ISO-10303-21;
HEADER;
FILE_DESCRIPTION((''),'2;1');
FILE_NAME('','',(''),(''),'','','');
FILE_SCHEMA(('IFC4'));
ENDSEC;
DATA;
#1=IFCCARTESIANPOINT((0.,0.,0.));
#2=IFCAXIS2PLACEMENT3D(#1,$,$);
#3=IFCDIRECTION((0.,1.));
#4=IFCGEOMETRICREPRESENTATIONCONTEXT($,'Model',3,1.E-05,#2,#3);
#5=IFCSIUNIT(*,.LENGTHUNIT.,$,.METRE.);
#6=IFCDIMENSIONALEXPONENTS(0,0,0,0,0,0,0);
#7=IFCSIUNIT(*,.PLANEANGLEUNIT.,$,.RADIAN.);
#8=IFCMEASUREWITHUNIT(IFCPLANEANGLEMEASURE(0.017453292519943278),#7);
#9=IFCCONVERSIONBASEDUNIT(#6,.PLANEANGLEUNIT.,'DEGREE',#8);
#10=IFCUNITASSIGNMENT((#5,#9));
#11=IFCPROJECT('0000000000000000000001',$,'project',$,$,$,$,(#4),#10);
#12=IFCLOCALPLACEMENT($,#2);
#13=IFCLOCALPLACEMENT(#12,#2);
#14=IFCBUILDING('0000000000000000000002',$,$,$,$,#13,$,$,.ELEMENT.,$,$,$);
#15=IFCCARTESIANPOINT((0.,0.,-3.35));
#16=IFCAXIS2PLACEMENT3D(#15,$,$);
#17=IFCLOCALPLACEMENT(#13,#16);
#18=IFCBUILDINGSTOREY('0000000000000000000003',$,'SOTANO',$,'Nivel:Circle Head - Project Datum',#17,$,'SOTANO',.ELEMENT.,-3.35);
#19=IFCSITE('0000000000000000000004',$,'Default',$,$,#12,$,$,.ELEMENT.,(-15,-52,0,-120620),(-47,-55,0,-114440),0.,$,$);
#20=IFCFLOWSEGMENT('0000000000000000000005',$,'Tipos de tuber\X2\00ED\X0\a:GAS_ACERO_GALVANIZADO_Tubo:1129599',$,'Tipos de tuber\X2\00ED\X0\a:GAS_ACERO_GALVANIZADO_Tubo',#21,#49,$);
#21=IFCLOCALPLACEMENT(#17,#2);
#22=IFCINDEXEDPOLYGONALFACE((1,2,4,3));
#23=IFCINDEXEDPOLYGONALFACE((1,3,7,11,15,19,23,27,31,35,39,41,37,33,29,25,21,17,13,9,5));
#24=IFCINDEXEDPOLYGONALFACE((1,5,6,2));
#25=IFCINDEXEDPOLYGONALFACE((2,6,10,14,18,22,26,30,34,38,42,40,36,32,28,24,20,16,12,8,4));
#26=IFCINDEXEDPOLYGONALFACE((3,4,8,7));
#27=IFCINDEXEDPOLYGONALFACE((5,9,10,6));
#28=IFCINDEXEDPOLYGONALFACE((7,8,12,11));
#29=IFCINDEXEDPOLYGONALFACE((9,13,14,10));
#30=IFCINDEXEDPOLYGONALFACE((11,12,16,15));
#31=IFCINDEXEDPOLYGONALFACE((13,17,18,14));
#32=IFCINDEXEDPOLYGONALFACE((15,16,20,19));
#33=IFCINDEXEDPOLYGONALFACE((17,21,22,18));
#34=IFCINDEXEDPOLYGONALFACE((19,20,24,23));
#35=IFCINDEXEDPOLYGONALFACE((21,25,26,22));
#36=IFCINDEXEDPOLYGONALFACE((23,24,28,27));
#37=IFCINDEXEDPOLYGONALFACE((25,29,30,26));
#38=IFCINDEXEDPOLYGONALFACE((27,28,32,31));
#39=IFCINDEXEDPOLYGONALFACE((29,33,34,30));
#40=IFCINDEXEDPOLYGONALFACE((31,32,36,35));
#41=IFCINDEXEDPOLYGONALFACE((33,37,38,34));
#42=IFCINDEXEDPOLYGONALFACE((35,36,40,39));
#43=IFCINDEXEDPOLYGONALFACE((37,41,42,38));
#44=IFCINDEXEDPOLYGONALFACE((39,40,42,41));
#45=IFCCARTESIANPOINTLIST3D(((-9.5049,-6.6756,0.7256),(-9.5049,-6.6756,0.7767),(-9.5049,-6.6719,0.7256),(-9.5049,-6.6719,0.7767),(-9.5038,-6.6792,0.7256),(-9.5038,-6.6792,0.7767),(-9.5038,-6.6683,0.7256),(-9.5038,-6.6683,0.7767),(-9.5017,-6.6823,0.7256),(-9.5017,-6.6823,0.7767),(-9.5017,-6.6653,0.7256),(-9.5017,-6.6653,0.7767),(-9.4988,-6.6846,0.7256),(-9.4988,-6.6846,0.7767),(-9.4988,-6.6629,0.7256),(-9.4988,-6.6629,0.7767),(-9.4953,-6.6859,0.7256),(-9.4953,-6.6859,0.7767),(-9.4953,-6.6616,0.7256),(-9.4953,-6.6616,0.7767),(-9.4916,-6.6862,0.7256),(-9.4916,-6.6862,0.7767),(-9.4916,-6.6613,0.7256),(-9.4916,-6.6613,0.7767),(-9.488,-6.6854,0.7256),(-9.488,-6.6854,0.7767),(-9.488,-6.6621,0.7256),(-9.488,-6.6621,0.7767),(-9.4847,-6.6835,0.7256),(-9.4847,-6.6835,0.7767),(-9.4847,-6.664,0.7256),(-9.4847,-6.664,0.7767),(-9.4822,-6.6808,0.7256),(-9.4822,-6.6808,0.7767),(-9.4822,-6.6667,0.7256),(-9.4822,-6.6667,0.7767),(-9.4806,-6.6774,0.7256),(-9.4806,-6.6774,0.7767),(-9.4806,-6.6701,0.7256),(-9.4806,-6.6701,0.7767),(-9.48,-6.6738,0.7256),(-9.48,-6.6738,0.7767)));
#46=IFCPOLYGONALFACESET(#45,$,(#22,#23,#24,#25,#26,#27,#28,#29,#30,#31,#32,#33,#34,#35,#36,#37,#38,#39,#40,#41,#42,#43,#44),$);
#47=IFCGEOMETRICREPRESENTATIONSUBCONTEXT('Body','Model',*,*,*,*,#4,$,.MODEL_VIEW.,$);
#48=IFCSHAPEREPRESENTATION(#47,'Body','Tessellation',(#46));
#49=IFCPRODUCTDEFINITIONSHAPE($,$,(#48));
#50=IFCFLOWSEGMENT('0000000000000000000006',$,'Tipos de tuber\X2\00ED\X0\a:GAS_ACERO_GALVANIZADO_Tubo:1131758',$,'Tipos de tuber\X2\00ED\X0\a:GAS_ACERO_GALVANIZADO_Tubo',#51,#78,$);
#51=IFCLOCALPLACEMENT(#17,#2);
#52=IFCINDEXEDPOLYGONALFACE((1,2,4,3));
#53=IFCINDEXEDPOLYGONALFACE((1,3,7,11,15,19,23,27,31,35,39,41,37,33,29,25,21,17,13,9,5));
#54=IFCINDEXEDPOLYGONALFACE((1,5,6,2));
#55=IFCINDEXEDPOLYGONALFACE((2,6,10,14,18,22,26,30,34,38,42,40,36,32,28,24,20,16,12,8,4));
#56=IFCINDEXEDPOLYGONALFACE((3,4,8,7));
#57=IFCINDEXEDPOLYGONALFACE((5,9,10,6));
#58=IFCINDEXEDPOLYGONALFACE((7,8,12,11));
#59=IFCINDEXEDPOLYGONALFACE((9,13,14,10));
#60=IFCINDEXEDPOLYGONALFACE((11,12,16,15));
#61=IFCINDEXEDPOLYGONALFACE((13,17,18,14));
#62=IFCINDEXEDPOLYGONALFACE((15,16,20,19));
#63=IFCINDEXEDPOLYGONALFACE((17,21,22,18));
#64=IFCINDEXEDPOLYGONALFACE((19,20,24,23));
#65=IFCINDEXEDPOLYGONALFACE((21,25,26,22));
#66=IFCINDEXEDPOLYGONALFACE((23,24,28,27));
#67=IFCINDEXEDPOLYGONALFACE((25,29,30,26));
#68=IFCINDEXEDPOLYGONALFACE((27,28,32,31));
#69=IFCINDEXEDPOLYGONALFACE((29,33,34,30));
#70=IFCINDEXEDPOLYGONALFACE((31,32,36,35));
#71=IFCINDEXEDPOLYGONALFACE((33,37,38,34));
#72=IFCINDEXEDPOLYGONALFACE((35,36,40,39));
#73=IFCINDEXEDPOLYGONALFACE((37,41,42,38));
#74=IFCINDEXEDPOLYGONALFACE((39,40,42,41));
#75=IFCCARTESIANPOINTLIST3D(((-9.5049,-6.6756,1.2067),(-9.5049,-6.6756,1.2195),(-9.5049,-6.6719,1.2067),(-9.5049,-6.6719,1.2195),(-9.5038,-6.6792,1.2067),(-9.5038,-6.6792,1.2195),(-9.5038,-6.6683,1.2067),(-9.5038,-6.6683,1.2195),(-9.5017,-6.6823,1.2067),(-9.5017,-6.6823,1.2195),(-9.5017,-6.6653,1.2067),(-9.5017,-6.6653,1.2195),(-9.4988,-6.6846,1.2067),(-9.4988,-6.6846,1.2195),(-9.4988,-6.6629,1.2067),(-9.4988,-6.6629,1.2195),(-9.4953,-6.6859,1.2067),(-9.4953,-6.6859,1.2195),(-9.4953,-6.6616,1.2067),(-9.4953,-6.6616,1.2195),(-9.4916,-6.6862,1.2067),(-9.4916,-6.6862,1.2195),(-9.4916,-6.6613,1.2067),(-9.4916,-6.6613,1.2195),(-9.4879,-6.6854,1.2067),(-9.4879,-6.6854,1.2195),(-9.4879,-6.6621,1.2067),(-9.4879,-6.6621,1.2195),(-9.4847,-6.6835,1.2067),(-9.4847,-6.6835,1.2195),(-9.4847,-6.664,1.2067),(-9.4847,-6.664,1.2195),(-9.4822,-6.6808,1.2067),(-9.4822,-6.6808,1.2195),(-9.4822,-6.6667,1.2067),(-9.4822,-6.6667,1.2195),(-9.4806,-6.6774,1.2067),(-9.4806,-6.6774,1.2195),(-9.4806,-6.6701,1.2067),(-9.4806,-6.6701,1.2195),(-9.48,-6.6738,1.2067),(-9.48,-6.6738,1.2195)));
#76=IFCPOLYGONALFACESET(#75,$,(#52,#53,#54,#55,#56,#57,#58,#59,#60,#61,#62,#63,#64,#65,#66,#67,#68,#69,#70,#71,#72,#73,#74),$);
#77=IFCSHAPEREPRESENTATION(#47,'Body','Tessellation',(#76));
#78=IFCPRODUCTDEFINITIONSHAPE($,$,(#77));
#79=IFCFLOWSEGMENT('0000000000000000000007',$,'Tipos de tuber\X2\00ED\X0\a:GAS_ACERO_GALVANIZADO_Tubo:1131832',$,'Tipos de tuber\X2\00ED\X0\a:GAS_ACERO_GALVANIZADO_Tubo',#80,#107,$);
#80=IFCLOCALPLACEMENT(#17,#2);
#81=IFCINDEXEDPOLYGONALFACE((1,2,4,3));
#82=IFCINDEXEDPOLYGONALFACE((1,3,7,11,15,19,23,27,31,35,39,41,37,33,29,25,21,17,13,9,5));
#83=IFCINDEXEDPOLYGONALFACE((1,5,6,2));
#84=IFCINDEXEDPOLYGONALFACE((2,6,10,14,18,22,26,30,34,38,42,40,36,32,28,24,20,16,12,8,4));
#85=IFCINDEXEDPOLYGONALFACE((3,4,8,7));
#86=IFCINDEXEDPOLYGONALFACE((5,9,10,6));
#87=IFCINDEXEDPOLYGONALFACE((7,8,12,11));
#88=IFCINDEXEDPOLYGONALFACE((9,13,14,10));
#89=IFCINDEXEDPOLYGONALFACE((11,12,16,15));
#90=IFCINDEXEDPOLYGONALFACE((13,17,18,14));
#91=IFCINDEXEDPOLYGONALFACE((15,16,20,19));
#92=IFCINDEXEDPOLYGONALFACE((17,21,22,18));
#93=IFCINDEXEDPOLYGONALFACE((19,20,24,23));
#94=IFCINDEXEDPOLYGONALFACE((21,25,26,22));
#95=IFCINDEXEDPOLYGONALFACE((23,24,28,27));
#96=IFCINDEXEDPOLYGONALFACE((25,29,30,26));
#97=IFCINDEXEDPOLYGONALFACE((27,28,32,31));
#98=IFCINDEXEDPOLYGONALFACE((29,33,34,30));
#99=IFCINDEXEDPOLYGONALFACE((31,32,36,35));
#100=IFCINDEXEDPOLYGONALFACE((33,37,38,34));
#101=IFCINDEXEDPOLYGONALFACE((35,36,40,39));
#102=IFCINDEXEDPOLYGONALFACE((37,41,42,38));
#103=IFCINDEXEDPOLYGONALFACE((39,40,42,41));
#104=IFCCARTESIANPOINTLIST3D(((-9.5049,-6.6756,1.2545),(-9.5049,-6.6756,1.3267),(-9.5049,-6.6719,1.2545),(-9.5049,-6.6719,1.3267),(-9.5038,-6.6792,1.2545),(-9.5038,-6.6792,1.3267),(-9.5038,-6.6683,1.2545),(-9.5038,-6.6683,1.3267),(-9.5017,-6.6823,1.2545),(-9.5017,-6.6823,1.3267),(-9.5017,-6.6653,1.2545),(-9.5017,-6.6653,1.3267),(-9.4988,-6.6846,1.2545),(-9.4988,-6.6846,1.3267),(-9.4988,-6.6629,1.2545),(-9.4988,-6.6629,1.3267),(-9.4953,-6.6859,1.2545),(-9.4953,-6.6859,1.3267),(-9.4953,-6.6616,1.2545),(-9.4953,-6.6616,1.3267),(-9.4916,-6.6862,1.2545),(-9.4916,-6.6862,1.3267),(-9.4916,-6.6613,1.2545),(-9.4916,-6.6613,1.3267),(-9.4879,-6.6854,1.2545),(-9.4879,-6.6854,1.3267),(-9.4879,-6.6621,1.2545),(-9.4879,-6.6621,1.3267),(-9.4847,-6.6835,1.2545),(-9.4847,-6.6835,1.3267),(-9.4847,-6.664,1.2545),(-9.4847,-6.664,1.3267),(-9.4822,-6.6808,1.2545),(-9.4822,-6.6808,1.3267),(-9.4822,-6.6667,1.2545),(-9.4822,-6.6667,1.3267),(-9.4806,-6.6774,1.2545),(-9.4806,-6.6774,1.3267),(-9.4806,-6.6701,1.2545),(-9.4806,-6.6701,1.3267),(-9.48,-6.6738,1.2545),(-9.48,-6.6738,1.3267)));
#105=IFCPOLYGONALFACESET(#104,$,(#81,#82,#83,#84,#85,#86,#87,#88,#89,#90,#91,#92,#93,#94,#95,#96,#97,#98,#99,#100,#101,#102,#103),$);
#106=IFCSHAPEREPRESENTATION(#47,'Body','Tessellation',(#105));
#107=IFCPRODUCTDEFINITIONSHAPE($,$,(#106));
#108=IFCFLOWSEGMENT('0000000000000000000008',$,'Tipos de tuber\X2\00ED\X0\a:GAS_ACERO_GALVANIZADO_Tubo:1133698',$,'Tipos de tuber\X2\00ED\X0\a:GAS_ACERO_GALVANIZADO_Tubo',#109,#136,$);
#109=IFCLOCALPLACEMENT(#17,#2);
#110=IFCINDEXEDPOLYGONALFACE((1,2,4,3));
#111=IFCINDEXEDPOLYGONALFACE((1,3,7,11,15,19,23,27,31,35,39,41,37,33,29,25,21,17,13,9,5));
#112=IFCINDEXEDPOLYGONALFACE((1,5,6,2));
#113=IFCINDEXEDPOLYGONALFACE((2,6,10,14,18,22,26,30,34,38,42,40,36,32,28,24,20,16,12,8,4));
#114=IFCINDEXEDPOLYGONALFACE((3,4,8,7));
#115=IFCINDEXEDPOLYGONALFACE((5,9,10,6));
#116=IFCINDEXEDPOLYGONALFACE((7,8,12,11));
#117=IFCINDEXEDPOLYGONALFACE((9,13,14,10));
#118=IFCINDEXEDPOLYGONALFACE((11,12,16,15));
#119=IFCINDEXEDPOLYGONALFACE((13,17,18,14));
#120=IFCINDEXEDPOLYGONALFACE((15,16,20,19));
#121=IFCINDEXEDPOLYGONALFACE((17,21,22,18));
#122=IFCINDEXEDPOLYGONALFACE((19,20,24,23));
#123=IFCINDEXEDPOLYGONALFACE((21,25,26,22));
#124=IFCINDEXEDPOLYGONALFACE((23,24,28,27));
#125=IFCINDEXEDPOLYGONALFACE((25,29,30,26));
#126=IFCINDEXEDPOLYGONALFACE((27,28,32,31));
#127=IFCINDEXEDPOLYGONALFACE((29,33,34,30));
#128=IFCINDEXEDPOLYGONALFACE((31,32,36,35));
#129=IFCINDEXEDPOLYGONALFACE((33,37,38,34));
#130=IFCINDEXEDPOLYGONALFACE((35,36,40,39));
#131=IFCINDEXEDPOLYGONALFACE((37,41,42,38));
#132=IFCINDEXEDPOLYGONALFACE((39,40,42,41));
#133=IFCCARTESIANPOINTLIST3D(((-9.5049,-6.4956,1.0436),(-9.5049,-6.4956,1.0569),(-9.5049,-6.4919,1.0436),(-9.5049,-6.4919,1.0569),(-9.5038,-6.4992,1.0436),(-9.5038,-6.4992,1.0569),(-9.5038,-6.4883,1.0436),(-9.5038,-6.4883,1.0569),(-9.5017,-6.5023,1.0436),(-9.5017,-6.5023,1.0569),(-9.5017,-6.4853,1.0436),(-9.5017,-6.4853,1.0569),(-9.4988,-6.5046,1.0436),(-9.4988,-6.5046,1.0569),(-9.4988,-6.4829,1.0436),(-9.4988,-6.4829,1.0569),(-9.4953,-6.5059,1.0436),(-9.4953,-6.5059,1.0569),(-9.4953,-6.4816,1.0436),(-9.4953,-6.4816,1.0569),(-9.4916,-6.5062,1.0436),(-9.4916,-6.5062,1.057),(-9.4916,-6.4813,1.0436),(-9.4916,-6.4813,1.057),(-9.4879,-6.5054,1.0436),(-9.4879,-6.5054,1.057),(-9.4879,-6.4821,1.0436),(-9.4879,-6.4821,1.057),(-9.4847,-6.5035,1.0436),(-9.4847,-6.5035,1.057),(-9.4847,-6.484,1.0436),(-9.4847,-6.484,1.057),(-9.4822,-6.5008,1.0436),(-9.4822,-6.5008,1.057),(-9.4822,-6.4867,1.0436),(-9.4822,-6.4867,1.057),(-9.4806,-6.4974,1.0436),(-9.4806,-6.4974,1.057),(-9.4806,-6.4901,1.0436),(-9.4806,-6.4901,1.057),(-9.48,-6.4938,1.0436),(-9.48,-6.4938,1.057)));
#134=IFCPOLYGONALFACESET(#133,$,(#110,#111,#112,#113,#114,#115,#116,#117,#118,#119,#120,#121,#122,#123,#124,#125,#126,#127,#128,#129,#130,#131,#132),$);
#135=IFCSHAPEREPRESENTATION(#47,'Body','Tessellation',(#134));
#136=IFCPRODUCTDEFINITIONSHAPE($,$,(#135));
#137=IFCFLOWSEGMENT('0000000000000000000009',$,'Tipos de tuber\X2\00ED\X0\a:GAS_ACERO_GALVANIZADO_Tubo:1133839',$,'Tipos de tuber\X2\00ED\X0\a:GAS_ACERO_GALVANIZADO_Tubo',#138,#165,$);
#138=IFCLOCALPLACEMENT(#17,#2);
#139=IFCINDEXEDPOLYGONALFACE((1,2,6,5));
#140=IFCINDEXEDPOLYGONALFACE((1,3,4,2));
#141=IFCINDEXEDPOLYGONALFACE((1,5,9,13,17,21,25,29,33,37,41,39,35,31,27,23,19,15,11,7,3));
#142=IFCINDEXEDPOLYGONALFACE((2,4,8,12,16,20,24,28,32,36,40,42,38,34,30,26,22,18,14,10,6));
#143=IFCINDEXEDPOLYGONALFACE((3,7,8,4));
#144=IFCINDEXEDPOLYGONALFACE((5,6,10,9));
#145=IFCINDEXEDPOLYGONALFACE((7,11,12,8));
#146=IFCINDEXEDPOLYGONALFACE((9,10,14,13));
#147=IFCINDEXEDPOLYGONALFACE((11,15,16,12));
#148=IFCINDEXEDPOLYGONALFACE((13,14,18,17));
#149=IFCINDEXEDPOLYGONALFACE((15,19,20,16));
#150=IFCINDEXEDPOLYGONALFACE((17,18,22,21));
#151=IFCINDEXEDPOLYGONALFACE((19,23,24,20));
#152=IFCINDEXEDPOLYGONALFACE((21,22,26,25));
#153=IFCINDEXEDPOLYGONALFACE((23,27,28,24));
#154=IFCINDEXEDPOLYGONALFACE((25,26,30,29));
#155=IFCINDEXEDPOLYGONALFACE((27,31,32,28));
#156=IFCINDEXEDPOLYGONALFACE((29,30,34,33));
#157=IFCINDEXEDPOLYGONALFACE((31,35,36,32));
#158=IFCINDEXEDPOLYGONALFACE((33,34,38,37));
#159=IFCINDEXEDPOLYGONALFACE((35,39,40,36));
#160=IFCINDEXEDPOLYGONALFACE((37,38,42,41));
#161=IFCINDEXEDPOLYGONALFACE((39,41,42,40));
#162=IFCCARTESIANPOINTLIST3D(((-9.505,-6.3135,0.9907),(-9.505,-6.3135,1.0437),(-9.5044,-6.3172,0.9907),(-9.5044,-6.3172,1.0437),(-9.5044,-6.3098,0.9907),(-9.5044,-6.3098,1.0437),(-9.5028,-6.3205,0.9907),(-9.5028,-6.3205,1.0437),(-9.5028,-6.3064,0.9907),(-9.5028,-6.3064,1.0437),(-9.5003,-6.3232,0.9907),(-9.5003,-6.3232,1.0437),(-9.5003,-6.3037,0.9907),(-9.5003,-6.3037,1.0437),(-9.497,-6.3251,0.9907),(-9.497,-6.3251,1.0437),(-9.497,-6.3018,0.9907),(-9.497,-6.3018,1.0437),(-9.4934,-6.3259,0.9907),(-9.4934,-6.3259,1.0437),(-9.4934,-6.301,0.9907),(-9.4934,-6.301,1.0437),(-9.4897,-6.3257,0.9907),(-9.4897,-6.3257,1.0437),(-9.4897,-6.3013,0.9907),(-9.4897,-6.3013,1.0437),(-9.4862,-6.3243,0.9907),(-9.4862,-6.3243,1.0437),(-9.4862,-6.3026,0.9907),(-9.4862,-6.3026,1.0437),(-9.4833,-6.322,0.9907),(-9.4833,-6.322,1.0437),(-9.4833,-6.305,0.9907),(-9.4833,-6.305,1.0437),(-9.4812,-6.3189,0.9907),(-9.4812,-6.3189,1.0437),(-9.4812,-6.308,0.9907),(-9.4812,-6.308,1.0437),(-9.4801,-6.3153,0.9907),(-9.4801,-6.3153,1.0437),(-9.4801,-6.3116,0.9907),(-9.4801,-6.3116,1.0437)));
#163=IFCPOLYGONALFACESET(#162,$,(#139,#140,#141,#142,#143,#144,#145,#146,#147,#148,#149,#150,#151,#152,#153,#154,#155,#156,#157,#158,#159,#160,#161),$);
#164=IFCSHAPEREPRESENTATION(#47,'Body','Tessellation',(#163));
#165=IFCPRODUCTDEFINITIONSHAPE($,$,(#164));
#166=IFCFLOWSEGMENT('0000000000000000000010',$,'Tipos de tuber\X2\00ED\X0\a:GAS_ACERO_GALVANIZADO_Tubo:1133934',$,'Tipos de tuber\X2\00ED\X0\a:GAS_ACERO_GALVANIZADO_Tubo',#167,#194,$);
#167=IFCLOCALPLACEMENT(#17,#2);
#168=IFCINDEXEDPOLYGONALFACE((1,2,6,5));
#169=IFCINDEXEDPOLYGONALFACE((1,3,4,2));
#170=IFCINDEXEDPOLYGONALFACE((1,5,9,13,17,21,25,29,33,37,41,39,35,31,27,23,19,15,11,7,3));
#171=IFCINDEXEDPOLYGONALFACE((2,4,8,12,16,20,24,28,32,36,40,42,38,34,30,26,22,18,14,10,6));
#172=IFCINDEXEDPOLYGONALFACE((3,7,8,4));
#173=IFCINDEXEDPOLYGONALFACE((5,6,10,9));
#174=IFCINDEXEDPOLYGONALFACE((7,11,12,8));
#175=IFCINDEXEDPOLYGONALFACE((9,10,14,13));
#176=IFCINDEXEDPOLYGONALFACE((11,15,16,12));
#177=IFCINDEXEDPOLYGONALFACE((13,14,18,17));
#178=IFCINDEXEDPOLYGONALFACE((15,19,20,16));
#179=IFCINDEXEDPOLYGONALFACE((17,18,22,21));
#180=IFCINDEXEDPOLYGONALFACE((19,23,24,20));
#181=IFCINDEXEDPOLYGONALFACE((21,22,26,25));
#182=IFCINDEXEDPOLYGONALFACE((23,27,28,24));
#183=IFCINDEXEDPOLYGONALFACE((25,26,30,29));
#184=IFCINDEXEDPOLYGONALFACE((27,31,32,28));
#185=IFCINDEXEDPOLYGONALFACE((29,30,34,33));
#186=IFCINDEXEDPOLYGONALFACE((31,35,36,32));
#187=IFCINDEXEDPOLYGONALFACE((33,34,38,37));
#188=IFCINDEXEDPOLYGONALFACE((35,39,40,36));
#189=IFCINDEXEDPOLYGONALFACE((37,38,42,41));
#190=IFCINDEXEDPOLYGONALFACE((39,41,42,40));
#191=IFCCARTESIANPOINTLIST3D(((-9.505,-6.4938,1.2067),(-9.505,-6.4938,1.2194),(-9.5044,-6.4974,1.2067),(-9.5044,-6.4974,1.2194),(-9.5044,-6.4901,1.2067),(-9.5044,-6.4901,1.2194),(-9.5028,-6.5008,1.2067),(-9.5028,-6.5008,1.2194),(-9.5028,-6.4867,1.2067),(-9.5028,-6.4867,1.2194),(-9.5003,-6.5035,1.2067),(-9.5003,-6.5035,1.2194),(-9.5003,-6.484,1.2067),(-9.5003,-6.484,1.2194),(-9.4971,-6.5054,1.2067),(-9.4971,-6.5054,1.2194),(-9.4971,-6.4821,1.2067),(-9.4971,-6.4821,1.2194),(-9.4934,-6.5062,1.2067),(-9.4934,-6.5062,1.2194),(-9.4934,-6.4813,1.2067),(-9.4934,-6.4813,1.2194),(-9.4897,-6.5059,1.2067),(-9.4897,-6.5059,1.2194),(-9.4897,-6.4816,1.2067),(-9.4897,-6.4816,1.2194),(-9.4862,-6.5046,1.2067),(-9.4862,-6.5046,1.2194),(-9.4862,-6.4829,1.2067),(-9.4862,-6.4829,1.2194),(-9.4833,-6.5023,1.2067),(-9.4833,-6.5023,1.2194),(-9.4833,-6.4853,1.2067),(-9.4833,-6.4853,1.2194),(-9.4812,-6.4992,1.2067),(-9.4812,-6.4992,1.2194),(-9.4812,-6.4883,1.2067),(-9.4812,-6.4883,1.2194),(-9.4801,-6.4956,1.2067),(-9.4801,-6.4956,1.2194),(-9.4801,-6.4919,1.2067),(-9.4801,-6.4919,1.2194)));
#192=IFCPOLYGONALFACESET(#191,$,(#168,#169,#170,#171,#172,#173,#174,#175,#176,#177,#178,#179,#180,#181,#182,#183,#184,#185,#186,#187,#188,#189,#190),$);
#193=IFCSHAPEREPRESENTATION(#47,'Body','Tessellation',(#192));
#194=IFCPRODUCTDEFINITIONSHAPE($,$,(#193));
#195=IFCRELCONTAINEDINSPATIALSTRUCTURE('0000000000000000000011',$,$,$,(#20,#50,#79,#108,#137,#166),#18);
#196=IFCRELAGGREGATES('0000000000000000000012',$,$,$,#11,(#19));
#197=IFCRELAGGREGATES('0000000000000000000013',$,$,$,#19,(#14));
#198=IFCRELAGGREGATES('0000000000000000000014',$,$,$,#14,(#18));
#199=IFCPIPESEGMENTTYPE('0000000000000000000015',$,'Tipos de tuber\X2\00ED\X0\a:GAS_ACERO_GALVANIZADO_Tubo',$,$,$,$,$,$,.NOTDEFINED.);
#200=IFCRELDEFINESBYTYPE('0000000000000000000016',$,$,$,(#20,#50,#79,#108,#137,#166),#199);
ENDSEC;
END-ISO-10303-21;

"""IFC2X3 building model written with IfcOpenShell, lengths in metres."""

from ifc_helpers import new_model, entity, si_unit, converted_unit, direction, frame, frame_2d, origin, origin_2d_with_axis, place, context, subcontext, project, spatial, circle, extrude, type_object, element, save


model = new_model("IFC2X3")

# Units and contexts
model_context = context("Model", 3, precision=1e-05, world=origin(), true_north=direction((0.0, 1.0)))
body_context = subcontext(model_context, "Body", "Model", "MODEL_VIEW")
ifc_project = project(units=[si_unit("LENGTHUNIT", "METRE"), converted_unit("PLANEANGLEUNIT", "DEGREE", entity("IfcPlaneAngleMeasure", 0.017453292519943278), si_unit("PLANEANGLEUNIT", "RADIAN"), dimensions=[0, 0, 0, 0, 0, 0, 0])], contexts=[model_context])

# Site, building, storey
site_placement = place(None, origin())
site = spatial("IfcSite", under=ifc_project, at=site_placement, Name="Default", CompositionType="ELEMENT", RefLatitude=(-15, -52, 0, -120620), RefLongitude=(-47, -55, 0, -114440), RefElevation=0.0)
building_placement = place(site_placement, origin())
building = spatial("IfcBuilding", under=site, at=building_placement, CompositionType="ELEMENT")
storey_placement = place(building_placement, frame((0.0, 0.0, -3.35)))
storey = spatial("IfcBuildingStorey", under=building, at=storey_placement, Name="SOTANO", ObjectType="Nivel:Circle Head - Project Datum", LongName="SOTANO", CompositionType="ELEMENT", Elevation=-3.35)

# Flow segments
pipe_segment_type_1 = type_object("IfcPipeSegmentType", Name="Tipos de tubería:GAS_ACERO_GALVANIZADO_Tubo", PredefinedType="NOTDEFINED")
flow_segment_1_placement = place(storey_placement, origin())
element("IfcFlowSegment", 1, at=flow_segment_1_placement, inside=storey, type_object=pipe_segment_type_1, Name="Tipos de tubería:GAS_ACERO_GALVANIZADO_Tubo:1129599", ObjectType="Tipos de tubería:GAS_ACERO_GALVANIZADO_Tubo", context=body_context, shape_type="SweptSolid", body=[
    extrude(circle(Radius=0.0125, at=origin_2d_with_axis()), frame((-9.4925, -6.6738, 0.7256)), (0.0, 0.0, 1.0), 0.051),
])
flow_segment_2_placement = place(storey_placement, origin())
element("IfcFlowSegment", 2, at=flow_segment_2_placement, inside=storey, type_object=pipe_segment_type_1, Name="Tipos de tubería:GAS_ACERO_GALVANIZADO_Tubo:1131758", ObjectType="Tipos de tubería:GAS_ACERO_GALVANIZADO_Tubo", context=body_context, shape_type="SweptSolid", body=[
    extrude(circle(Radius=0.0125, at=origin_2d_with_axis()), frame((-9.4925, -6.6738, 1.2067)), (0.0, 0.0, 1.0), 0.0128),
])
flow_segment_3_placement = place(storey_placement, origin())
element("IfcFlowSegment", 3, at=flow_segment_3_placement, inside=storey, type_object=pipe_segment_type_1, Name="Tipos de tubería:GAS_ACERO_GALVANIZADO_Tubo:1131832", ObjectType="Tipos de tubería:GAS_ACERO_GALVANIZADO_Tubo", context=body_context, shape_type="SweptSolid", body=[
    extrude(circle(Radius=0.0125, at=frame_2d((0.0, 0.0), x_axis=(1.0, 0.0))), frame((-9.4925, -6.6738, 1.2545)), (0.0, 0.0, 1.0), 0.0722),
])
flow_segment_4_placement = place(storey_placement, origin())
element("IfcFlowSegment", 4, at=flow_segment_4_placement, inside=storey, type_object=pipe_segment_type_1, Name="Tipos de tubería:GAS_ACERO_GALVANIZADO_Tubo:1133698", ObjectType="Tipos de tubería:GAS_ACERO_GALVANIZADO_Tubo", context=body_context, shape_type="SweptSolid", body=[
    extrude(circle(Radius=0.0125, at=frame_2d((0.0, 0.0), x_axis=(1.0, 0.0))), frame((-9.4925, -6.4938, 1.0436), z_axis=(-0.000174, 0.0, 1.0), x_axis=(1.0, 0.0, 0.000174)), (0.0, 0.0, 1.0), 0.0133),
])
flow_segment_5_placement = place(storey_placement, origin())
element("IfcFlowSegment", 5, at=flow_segment_5_placement, inside=storey, type_object=pipe_segment_type_1, Name="Tipos de tubería:GAS_ACERO_GALVANIZADO_Tubo:1133839", ObjectType="Tipos de tubería:GAS_ACERO_GALVANIZADO_Tubo", context=body_context, shape_type="SweptSolid", body=[
    extrude(circle(Radius=0.0125, at=origin_2d_with_axis()), frame((-9.4925, -6.3135, 0.9907), z_axis=(-0.000135, 0.0, 1.0), x_axis=(-1.0, 0.0, -0.000135)), (0.0, 0.0, 1.0), 0.053),
])
flow_segment_6_placement = place(storey_placement, origin())
element("IfcFlowSegment", 6, at=flow_segment_6_placement, inside=storey, type_object=pipe_segment_type_1, Name="Tipos de tubería:GAS_ACERO_GALVANIZADO_Tubo:1133934", ObjectType="Tipos de tubería:GAS_ACERO_GALVANIZADO_Tubo", context=body_context, shape_type="SweptSolid", body=[
    extrude(circle(Radius=0.0125, at=origin_2d_with_axis()), frame((-9.4925, -6.4938, 1.2067), z_axis=(0.000002, 0.0, 1.0), x_axis=(-1.0, 0.0, 0.000002)), (0.0, 0.0, 1.0), 0.0128),
])

save(model, "model.ifc")
